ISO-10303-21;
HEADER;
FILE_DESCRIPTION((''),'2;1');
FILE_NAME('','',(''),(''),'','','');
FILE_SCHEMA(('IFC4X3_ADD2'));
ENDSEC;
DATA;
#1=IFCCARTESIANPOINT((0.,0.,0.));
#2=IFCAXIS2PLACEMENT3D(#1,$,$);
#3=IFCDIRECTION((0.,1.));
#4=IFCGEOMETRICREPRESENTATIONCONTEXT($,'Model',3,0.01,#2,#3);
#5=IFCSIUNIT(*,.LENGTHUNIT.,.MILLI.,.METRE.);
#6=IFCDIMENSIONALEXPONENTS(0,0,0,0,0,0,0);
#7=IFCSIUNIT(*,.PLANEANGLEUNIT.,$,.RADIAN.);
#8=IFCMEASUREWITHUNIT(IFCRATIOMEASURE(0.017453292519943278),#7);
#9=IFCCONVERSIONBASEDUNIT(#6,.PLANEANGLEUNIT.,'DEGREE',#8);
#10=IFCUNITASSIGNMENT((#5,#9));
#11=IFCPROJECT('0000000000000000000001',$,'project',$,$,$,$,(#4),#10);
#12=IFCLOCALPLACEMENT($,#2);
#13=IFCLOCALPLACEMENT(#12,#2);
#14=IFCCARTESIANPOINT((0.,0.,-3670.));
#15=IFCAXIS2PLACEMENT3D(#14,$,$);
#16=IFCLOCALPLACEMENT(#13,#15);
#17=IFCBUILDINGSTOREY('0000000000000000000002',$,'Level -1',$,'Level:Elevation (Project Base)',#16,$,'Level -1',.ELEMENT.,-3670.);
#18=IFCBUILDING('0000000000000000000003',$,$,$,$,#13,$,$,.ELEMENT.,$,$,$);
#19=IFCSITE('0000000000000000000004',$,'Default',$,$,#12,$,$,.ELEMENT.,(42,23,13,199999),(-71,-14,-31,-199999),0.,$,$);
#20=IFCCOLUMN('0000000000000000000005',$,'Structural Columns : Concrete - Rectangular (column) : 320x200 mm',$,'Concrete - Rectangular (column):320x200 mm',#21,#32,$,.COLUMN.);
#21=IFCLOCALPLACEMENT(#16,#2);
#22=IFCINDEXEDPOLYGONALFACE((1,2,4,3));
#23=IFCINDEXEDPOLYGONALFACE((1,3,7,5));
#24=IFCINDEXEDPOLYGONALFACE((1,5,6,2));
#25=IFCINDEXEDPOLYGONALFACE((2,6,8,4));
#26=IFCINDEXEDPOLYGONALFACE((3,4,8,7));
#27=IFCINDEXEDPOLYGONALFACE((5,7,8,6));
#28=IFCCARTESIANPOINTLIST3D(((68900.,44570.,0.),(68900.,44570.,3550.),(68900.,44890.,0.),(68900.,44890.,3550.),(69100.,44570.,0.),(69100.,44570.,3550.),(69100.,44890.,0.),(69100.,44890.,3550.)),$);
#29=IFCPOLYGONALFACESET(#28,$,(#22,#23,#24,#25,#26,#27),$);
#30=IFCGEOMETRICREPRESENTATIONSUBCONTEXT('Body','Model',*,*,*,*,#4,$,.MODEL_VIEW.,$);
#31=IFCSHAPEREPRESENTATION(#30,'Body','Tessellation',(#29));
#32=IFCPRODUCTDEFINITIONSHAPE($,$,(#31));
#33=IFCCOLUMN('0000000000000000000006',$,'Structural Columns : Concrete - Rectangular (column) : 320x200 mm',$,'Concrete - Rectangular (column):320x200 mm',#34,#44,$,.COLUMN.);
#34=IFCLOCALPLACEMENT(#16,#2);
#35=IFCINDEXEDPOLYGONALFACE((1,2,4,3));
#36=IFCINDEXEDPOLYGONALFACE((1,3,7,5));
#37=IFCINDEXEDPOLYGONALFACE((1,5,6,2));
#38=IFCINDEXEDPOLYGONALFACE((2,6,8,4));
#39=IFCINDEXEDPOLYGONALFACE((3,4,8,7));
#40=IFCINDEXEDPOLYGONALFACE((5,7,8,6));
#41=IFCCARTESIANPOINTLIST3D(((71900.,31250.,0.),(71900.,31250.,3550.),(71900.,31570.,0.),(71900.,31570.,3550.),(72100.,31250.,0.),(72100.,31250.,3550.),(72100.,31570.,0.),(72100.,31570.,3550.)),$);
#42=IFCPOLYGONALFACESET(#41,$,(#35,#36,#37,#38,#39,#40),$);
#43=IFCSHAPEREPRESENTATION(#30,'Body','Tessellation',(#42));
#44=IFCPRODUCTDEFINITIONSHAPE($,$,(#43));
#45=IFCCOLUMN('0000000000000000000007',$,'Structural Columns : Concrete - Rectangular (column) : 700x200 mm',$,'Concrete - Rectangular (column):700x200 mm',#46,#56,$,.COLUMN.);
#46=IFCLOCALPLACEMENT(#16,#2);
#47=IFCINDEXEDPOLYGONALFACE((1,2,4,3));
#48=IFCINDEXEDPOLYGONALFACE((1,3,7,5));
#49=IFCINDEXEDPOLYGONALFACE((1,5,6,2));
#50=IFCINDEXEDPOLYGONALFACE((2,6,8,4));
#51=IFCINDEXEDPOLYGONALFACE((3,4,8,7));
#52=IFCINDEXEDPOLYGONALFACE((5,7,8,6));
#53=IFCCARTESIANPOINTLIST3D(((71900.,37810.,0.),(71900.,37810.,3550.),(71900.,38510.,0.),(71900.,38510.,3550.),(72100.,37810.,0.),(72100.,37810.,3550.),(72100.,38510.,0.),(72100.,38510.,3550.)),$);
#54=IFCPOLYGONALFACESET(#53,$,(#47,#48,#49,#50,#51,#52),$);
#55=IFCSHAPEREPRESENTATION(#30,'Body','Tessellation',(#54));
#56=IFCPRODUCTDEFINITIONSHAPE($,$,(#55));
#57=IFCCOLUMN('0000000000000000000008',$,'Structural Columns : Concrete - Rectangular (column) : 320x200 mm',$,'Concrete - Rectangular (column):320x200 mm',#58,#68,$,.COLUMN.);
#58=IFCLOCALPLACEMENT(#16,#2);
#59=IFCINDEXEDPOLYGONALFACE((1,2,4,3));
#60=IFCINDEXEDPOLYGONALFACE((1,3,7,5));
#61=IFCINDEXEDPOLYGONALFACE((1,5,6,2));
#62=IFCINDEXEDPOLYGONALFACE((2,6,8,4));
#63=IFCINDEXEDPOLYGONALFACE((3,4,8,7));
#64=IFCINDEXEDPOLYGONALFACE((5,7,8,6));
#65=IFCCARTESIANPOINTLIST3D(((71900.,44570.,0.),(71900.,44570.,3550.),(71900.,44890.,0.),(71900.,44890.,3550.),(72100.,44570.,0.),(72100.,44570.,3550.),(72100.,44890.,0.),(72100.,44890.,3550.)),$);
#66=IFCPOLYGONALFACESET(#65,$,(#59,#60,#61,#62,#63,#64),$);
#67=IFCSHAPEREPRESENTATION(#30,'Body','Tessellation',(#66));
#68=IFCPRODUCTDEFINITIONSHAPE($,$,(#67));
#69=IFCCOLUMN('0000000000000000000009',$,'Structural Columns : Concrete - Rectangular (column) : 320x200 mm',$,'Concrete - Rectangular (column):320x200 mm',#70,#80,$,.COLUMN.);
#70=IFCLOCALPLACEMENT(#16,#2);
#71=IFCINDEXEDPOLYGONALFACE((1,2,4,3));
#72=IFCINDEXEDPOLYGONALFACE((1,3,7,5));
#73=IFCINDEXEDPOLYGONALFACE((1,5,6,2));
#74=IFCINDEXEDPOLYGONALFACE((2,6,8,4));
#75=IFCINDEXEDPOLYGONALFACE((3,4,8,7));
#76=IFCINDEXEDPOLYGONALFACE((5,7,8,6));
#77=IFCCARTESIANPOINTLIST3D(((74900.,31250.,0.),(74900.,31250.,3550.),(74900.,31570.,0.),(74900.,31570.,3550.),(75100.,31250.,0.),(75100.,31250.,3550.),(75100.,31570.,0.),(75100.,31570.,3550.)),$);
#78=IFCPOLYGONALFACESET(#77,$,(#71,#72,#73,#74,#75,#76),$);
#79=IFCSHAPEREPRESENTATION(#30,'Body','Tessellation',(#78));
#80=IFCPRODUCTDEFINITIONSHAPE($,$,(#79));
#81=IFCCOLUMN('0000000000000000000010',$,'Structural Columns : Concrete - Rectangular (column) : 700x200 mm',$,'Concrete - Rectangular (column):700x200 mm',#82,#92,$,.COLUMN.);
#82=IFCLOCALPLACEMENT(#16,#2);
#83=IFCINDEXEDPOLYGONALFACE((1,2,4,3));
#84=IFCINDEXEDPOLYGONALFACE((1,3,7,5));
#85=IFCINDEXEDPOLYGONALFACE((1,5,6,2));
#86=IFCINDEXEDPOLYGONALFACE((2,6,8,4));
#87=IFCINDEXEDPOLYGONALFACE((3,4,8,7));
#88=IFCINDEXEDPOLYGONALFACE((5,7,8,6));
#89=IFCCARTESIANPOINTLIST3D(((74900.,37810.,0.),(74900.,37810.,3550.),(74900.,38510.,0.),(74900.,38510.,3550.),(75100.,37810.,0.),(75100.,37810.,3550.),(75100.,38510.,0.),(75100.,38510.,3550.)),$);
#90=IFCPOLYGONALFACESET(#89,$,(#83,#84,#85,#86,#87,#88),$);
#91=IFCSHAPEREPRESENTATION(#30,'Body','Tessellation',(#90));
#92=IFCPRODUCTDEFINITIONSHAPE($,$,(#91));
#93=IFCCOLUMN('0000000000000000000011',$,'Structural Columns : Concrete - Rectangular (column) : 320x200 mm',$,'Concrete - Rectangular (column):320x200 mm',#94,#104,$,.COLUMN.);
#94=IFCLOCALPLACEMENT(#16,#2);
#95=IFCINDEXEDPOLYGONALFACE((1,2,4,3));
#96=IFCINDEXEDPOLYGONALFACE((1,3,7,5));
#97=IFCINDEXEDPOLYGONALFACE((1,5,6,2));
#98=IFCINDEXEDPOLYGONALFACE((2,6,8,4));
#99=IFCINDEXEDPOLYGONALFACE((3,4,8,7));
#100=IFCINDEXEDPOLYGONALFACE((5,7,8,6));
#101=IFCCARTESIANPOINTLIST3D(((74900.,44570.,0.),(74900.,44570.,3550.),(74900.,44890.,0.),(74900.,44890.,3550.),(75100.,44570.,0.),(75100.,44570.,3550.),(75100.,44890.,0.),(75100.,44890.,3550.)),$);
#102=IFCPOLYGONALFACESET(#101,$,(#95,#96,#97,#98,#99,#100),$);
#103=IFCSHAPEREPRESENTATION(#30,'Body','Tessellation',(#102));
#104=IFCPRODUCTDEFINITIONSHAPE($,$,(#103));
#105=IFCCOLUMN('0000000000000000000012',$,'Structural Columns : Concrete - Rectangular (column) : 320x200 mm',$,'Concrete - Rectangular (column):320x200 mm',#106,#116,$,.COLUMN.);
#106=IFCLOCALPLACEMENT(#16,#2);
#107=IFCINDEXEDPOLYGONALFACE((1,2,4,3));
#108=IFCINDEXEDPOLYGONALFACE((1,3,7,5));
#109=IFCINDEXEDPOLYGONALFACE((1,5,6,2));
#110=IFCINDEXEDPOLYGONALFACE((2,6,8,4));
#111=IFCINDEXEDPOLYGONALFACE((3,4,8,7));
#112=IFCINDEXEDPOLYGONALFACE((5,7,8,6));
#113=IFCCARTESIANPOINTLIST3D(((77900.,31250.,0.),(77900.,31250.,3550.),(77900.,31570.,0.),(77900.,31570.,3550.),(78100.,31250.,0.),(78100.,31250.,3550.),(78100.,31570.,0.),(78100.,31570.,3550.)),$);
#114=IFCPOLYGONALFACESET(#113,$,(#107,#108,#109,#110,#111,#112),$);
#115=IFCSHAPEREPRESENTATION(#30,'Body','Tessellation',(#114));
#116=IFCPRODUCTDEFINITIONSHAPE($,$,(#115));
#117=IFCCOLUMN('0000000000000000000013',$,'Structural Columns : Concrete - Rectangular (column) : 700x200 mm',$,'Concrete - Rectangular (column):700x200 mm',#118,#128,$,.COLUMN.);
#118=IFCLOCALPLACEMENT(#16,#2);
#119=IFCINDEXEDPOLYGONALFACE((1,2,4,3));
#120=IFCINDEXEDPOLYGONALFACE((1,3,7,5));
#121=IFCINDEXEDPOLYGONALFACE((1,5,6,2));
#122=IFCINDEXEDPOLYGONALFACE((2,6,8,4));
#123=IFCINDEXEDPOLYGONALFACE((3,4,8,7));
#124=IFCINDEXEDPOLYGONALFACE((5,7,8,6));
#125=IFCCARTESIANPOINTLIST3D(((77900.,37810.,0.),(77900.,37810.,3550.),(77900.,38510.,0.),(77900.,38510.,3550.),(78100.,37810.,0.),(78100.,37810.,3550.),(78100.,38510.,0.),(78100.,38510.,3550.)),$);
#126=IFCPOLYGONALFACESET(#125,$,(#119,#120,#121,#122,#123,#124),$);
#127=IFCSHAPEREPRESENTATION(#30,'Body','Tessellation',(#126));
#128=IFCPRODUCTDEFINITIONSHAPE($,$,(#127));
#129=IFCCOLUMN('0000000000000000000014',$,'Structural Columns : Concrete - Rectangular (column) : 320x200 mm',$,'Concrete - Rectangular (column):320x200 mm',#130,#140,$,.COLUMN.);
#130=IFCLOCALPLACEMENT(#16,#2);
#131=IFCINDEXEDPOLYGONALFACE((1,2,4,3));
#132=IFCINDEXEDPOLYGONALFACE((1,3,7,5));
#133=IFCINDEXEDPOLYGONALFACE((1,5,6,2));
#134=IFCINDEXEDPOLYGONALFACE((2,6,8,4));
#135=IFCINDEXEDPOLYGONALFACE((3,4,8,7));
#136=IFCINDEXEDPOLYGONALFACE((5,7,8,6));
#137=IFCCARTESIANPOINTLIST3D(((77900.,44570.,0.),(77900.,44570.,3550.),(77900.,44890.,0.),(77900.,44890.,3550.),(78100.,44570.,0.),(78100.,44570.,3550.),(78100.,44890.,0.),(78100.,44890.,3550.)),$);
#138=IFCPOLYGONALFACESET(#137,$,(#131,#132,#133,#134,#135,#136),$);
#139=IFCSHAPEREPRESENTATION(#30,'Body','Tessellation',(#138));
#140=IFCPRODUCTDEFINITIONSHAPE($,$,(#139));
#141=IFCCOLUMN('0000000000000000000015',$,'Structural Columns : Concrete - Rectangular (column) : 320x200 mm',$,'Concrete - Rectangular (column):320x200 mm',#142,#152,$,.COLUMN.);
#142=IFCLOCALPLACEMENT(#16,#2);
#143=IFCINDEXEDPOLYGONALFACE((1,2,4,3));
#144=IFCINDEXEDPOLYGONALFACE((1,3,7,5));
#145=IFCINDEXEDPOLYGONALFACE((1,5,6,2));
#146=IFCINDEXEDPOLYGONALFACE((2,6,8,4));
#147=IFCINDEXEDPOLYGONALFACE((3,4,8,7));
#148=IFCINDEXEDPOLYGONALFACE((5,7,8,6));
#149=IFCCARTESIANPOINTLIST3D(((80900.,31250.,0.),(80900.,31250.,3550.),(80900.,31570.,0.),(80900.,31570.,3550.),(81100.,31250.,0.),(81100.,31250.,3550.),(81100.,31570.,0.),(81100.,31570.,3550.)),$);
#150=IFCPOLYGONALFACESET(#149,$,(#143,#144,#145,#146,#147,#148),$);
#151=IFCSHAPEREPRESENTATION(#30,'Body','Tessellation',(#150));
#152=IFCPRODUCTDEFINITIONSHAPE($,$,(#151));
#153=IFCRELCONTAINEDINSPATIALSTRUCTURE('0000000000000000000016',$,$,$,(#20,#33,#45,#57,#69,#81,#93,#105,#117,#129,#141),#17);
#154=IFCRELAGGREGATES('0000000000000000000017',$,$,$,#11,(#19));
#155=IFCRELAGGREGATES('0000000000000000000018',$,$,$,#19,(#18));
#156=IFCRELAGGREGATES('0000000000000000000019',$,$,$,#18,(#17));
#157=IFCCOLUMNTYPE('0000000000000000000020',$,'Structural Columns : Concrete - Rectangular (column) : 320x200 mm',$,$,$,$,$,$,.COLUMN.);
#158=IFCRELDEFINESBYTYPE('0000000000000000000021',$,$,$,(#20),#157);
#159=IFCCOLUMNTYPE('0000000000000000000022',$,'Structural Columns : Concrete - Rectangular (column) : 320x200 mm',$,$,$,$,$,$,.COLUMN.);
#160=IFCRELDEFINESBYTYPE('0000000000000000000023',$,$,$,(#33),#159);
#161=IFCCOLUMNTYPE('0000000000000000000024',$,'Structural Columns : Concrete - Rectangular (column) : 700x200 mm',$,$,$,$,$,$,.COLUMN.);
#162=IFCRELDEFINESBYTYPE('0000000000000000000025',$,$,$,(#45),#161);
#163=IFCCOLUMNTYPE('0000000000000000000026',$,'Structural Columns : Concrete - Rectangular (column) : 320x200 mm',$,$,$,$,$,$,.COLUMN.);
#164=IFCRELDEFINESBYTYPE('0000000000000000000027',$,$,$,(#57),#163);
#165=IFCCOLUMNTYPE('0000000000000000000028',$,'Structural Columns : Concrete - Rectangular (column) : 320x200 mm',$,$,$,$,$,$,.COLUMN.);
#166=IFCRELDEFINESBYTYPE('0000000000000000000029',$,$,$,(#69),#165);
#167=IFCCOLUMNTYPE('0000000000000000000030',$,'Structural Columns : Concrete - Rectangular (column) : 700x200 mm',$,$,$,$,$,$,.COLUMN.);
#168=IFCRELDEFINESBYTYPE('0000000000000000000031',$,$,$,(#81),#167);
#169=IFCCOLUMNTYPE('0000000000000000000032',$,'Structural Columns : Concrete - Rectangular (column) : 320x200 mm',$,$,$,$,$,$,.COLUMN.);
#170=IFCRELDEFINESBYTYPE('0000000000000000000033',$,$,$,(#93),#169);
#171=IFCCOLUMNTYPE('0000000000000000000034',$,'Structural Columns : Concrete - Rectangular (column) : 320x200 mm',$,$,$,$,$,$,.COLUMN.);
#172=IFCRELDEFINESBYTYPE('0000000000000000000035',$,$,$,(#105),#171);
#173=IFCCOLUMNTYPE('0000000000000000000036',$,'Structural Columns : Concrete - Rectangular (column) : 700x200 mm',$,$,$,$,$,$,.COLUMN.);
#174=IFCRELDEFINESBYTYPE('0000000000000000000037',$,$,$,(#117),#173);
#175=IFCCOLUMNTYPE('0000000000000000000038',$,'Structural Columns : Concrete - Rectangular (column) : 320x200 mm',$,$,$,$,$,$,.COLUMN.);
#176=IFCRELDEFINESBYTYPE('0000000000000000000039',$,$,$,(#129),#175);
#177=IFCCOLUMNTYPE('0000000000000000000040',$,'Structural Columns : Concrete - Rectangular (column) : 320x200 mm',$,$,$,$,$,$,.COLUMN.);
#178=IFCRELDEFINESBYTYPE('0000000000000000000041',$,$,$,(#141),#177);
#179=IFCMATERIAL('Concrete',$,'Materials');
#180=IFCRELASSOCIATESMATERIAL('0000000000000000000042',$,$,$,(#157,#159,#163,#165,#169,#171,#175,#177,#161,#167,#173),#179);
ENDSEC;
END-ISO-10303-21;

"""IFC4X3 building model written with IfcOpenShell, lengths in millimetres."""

from ifc_helpers import new_model, entity, si_unit, converted_unit, direction, frame, frame_2d, origin, origin_2d_with_axis, place, context, subcontext, project, spatial, rectangle, extrude, source, transform, mapped, material, material_profile, profile_set, type_object, type_shapes, element, save


model = new_model("IFC4X3")

# Units and contexts
model_context = context("Model", 3, precision=0.01, world=origin(), true_north=direction((0.0, 1.0)))
body_context = subcontext(model_context, "Body", "Model", "MODEL_VIEW")
ifc_project = project(units=[si_unit("LENGTHUNIT", "METRE", prefix="MILLI"), converted_unit("PLANEANGLEUNIT", "DEGREE", entity("IfcRatioMeasure", 0.017453292519943278), si_unit("PLANEANGLEUNIT", "RADIAN"), dimensions=[0, 0, 0, 0, 0, 0, 0])], contexts=[model_context])

# Site, building, storey
site_placement = place(None, origin())
site = spatial("IfcSite", under=ifc_project, at=site_placement, Name="Default", CompositionType="ELEMENT", RefLatitude=(42, 23, 13, 199999), RefLongitude=(-71, -14, -31, -199999), RefElevation=0.0)
building_placement = place(site_placement, origin())
building = spatial("IfcBuilding", under=site, at=building_placement, CompositionType="ELEMENT")
storey_placement = place(building_placement, frame((0.0, 0.0, -3670.0)))
storey = spatial("IfcBuildingStorey", under=building, at=storey_placement, Name="Level -1", ObjectType="Level:Elevation (Project Base)", LongName="Level -1", CompositionType="ELEMENT", Elevation=-3670.0)

# Columns
ifc_material = material(Name="Concrete", Category="Materials")
ifc_material_profile_1 = material_profile(ifc_material, rectangle(XDim=320.0, YDim=200.0, at=frame_2d((0.0, 0.0), x_axis=(1.0, 0.0))), Name="320x200 mm")
ifc_profile_set_1 = profile_set([ifc_material_profile_1], Name="320x200 mm")
column_type_1 = type_object("IfcColumnType", Name="Structural Columns : Concrete - Rectangular (column) : 320x200 mm", PredefinedType="COLUMN", material=ifc_profile_set_1)
shared_shape_1 = source(origin(), body_context, "Body", "SweptSolid", [
    extrude(rectangle(XDim=320.0, YDim=200.0, at=origin_2d_with_axis()), frame((69000.0, 44730.0, -3670.0), z_axis=(0.0, 0.0, 1.0), x_axis=(0.0, -1.0, 0.0)), (0.0, 0.0, 1.0), 3550.0),
])
type_shapes(column_type_1, [shared_shape_1])
column_1_placement = place(storey_placement, frame((0.0, 0.0, 3670.0)))
element("IfcColumn", 1, at=column_1_placement, inside=storey, type_object=column_type_1, Name="Structural Columns : Concrete - Rectangular (column) : 320x200 mm", ObjectType="Concrete - Rectangular (column):320x200 mm", PredefinedType="COLUMN", context=body_context, shape_type="MappedRepresentation", body=[
    mapped(shared_shape_1, transform((0.0, 0.0, 0.0), scale=1.0)),
])
column_type_2 = type_object("IfcColumnType", Name="Structural Columns : Concrete - Rectangular (column) : 320x200 mm", PredefinedType="COLUMN", material=ifc_profile_set_1)
shared_shape_2 = source(origin(), body_context, "Body", "SweptSolid", [
    extrude(rectangle(XDim=320.0, YDim=200.0, at=origin_2d_with_axis()), frame((72000.0, 31410.0, -3670.0), z_axis=(0.0, 0.0, 1.0), x_axis=(0.0, -1.0, 0.0)), (0.0, 0.0, 1.0), 3550.0),
])
type_shapes(column_type_2, [shared_shape_2])
column_2_placement = place(storey_placement, frame((0.0, 0.0, 3670.0)))
element("IfcColumn", 2, at=column_2_placement, inside=storey, type_object=column_type_2, Name="Structural Columns : Concrete - Rectangular (column) : 320x200 mm", ObjectType="Concrete - Rectangular (column):320x200 mm", PredefinedType="COLUMN", context=body_context, shape_type="MappedRepresentation", body=[
    mapped(shared_shape_2, transform((0.0, 0.0, 0.0), scale=1.0)),
])
ifc_material_profile_2 = material_profile(ifc_material, rectangle(XDim=700.0, YDim=200.0, at=frame_2d((0.0, 0.0), x_axis=(1.0, 0.0))), Name="700x200 mm")
ifc_profile_set_2 = profile_set([ifc_material_profile_2], Name="700x200 mm")
column_type_3 = type_object("IfcColumnType", Name="Structural Columns : Concrete - Rectangular (column) : 700x200 mm", PredefinedType="COLUMN", material=ifc_profile_set_2)
shared_shape_3 = source(origin(), body_context, "Body", "SweptSolid", [
    extrude(rectangle(XDim=700.0, YDim=200.0, at=origin_2d_with_axis()), frame((72000.0, 38160.0, -3670.0), z_axis=(0.0, 0.0, 1.0), x_axis=(0.0, -1.0, 0.0)), (0.0, 0.0, 1.0), 3550.0),
])
type_shapes(column_type_3, [shared_shape_3])
column_3_placement = place(storey_placement, frame((0.0, 0.0, 3670.0)))
element("IfcColumn", 3, at=column_3_placement, inside=storey, type_object=column_type_3, Name="Structural Columns : Concrete - Rectangular (column) : 700x200 mm", ObjectType="Concrete - Rectangular (column):700x200 mm", PredefinedType="COLUMN", context=body_context, shape_type="MappedRepresentation", body=[
    mapped(shared_shape_3, transform((0.0, 0.0, 0.0), scale=1.0)),
])
column_type_4 = type_object("IfcColumnType", Name="Structural Columns : Concrete - Rectangular (column) : 320x200 mm", PredefinedType="COLUMN", material=ifc_profile_set_1)
shared_shape_4 = source(origin(), body_context, "Body", "SweptSolid", [
    extrude(rectangle(XDim=320.0, YDim=200.0, at=origin_2d_with_axis()), frame((72000.0, 44730.0, -3670.0), z_axis=(0.0, 0.0, 1.0), x_axis=(0.0, -1.0, 0.0)), (0.0, 0.0, 1.0), 3550.0),
])
type_shapes(column_type_4, [shared_shape_4])
column_4_placement = place(storey_placement, frame((0.0, 0.0, 3670.0)))
element("IfcColumn", 4, at=column_4_placement, inside=storey, type_object=column_type_4, Name="Structural Columns : Concrete - Rectangular (column) : 320x200 mm", ObjectType="Concrete - Rectangular (column):320x200 mm", PredefinedType="COLUMN", context=body_context, shape_type="MappedRepresentation", body=[
    mapped(shared_shape_4, transform((0.0, 0.0, 0.0), scale=1.0)),
])
column_type_5 = type_object("IfcColumnType", Name="Structural Columns : Concrete - Rectangular (column) : 320x200 mm", PredefinedType="COLUMN", material=ifc_profile_set_1)
shared_shape_5 = source(origin(), body_context, "Body", "SweptSolid", [
    extrude(rectangle(XDim=320.0, YDim=200.0, at=frame_2d((0.0, 0.0), x_axis=(1.0, 0.0))), frame((75000.0, 31410.0, -3670.0), z_axis=(0.0, 0.0, 1.0), x_axis=(0.0, -1.0, 0.0)), (0.0, 0.0, 1.0), 3550.0),
])
type_shapes(column_type_5, [shared_shape_5])
column_5_placement = place(storey_placement, frame((0.0, 0.0, 3670.0)))
element("IfcColumn", 5, at=column_5_placement, inside=storey, type_object=column_type_5, Name="Structural Columns : Concrete - Rectangular (column) : 320x200 mm", ObjectType="Concrete - Rectangular (column):320x200 mm", PredefinedType="COLUMN", context=body_context, shape_type="MappedRepresentation", body=[
    mapped(shared_shape_5, transform((0.0, 0.0, 0.0), scale=1.0)),
])
column_type_6 = type_object("IfcColumnType", Name="Structural Columns : Concrete - Rectangular (column) : 700x200 mm", PredefinedType="COLUMN", material=ifc_profile_set_2)
shared_shape_6 = source(origin(), body_context, "Body", "SweptSolid", [
    extrude(rectangle(XDim=700.0, YDim=200.0, at=frame_2d((0.0, 0.0), x_axis=(1.0, 0.0))), frame((75000.0, 38160.0, -3670.0), z_axis=(0.0, 0.0, 1.0), x_axis=(0.0, -1.0, 0.0)), (0.0, 0.0, 1.0), 3550.0),
])
type_shapes(column_type_6, [shared_shape_6])
column_6_placement = place(storey_placement, frame((0.0, 0.0, 3670.0)))
element("IfcColumn", 6, at=column_6_placement, inside=storey, type_object=column_type_6, Name="Structural Columns : Concrete - Rectangular (column) : 700x200 mm", ObjectType="Concrete - Rectangular (column):700x200 mm", PredefinedType="COLUMN", context=body_context, shape_type="MappedRepresentation", body=[
    mapped(shared_shape_6, transform((0.0, 0.0, 0.0), scale=1.0)),
])
column_type_7 = type_object("IfcColumnType", Name="Structural Columns : Concrete - Rectangular (column) : 320x200 mm", PredefinedType="COLUMN", material=ifc_profile_set_1)
shared_shape_7 = source(origin(), body_context, "Body", "SweptSolid", [
    extrude(rectangle(XDim=320.0, YDim=200.0, at=origin_2d_with_axis()), frame((75000.0, 44730.0, -3670.0), z_axis=(0.0, 0.0, 1.0), x_axis=(0.0, -1.0, 0.0)), (0.0, 0.0, 1.0), 3550.0),
])
type_shapes(column_type_7, [shared_shape_7])
column_7_placement = place(storey_placement, frame((0.0, 0.0, 3670.0)))
element("IfcColumn", 7, at=column_7_placement, inside=storey, type_object=column_type_7, Name="Structural Columns : Concrete - Rectangular (column) : 320x200 mm", ObjectType="Concrete - Rectangular (column):320x200 mm", PredefinedType="COLUMN", context=body_context, shape_type="MappedRepresentation", body=[
    mapped(shared_shape_7, transform((0.0, 0.0, 0.0), scale=1.0)),
])
column_type_8 = type_object("IfcColumnType", Name="Structural Columns : Concrete - Rectangular (column) : 320x200 mm", PredefinedType="COLUMN", material=ifc_profile_set_1)
shared_shape_8 = source(origin(), body_context, "Body", "SweptSolid", [
    extrude(rectangle(XDim=320.0, YDim=200.0, at=frame_2d((0.0, 0.0), x_axis=(1.0, 0.0))), frame((78000.0, 31410.0, -3670.0), z_axis=(0.0, 0.0, 1.0), x_axis=(0.0, -1.0, 0.0)), (0.0, 0.0, 1.0), 3550.0),
])
type_shapes(column_type_8, [shared_shape_8])
column_8_placement = place(storey_placement, frame((0.0, 0.0, 3670.0)))
element("IfcColumn", 8, at=column_8_placement, inside=storey, type_object=column_type_8, Name="Structural Columns : Concrete - Rectangular (column) : 320x200 mm", ObjectType="Concrete - Rectangular (column):320x200 mm", PredefinedType="COLUMN", context=body_context, shape_type="MappedRepresentation", body=[
    mapped(shared_shape_8, transform((0.0, 0.0, 0.0), scale=1.0)),
])
column_type_9 = type_object("IfcColumnType", Name="Structural Columns : Concrete - Rectangular (column) : 700x200 mm", PredefinedType="COLUMN", material=ifc_profile_set_2)
shared_shape_9 = source(origin(), body_context, "Body", "SweptSolid", [
    extrude(rectangle(XDim=700.0, YDim=200.0, at=frame_2d((0.0, 0.0), x_axis=(1.0, 0.0))), frame((78000.0, 38160.0, -3670.0), z_axis=(0.0, 0.0, 1.0), x_axis=(0.0, -1.0, 0.0)), (0.0, 0.0, 1.0), 3550.0),
])
type_shapes(column_type_9, [shared_shape_9])
column_9_placement = place(storey_placement, frame((0.0, 0.0, 3670.0)))
element("IfcColumn", 9, at=column_9_placement, inside=storey, type_object=column_type_9, Name="Structural Columns : Concrete - Rectangular (column) : 700x200 mm", ObjectType="Concrete - Rectangular (column):700x200 mm", PredefinedType="COLUMN", context=body_context, shape_type="MappedRepresentation", body=[
    mapped(shared_shape_9, transform((0.0, 0.0, 0.0), scale=1.0)),
])
column_type_10 = type_object("IfcColumnType", Name="Structural Columns : Concrete - Rectangular (column) : 320x200 mm", PredefinedType="COLUMN", material=ifc_profile_set_1)
shared_shape_10 = source(origin(), body_context, "Body", "SweptSolid", [
    extrude(rectangle(XDim=320.0, YDim=200.0, at=frame_2d((0.0, 0.0), x_axis=(1.0, 0.0))), frame((78000.0, 44730.0, -3670.0), z_axis=(0.0, 0.0, 1.0), x_axis=(0.0, -1.0, 0.0)), (0.0, 0.0, 1.0), 3550.0),
])
type_shapes(column_type_10, [shared_shape_10])
column_10_placement = place(storey_placement, frame((0.0, 0.0, 3670.0)))
element("IfcColumn", 10, at=column_10_placement, inside=storey, type_object=column_type_10, Name="Structural Columns : Concrete - Rectangular (column) : 320x200 mm", ObjectType="Concrete - Rectangular (column):320x200 mm", PredefinedType="COLUMN", context=body_context, shape_type="MappedRepresentation", body=[
    mapped(shared_shape_10, transform((0.0, 0.0, 0.0), scale=1.0)),
])
column_type_11 = type_object("IfcColumnType", Name="Structural Columns : Concrete - Rectangular (column) : 320x200 mm", PredefinedType="COLUMN", material=ifc_profile_set_1)
shared_shape_11 = source(origin(), body_context, "Body", "SweptSolid", [
    extrude(rectangle(XDim=320.0, YDim=200.0, at=origin_2d_with_axis()), frame((81000.0, 31410.0, -3670.0), z_axis=(0.0, 0.0, 1.0), x_axis=(0.0, -1.0, 0.0)), (0.0, 0.0, 1.0), 3550.0),
])
type_shapes(column_type_11, [shared_shape_11])
column_11_placement = place(storey_placement, frame((0.0, 0.0, 3670.0)))
element("IfcColumn", 11, at=column_11_placement, inside=storey, type_object=column_type_11, Name="Structural Columns : Concrete - Rectangular (column) : 320x200 mm", ObjectType="Concrete - Rectangular (column):320x200 mm", PredefinedType="COLUMN", context=body_context, shape_type="MappedRepresentation", body=[
    mapped(shared_shape_11, transform((0.0, 0.0, 0.0), scale=1.0)),
])

save(model, "model.ifc")
